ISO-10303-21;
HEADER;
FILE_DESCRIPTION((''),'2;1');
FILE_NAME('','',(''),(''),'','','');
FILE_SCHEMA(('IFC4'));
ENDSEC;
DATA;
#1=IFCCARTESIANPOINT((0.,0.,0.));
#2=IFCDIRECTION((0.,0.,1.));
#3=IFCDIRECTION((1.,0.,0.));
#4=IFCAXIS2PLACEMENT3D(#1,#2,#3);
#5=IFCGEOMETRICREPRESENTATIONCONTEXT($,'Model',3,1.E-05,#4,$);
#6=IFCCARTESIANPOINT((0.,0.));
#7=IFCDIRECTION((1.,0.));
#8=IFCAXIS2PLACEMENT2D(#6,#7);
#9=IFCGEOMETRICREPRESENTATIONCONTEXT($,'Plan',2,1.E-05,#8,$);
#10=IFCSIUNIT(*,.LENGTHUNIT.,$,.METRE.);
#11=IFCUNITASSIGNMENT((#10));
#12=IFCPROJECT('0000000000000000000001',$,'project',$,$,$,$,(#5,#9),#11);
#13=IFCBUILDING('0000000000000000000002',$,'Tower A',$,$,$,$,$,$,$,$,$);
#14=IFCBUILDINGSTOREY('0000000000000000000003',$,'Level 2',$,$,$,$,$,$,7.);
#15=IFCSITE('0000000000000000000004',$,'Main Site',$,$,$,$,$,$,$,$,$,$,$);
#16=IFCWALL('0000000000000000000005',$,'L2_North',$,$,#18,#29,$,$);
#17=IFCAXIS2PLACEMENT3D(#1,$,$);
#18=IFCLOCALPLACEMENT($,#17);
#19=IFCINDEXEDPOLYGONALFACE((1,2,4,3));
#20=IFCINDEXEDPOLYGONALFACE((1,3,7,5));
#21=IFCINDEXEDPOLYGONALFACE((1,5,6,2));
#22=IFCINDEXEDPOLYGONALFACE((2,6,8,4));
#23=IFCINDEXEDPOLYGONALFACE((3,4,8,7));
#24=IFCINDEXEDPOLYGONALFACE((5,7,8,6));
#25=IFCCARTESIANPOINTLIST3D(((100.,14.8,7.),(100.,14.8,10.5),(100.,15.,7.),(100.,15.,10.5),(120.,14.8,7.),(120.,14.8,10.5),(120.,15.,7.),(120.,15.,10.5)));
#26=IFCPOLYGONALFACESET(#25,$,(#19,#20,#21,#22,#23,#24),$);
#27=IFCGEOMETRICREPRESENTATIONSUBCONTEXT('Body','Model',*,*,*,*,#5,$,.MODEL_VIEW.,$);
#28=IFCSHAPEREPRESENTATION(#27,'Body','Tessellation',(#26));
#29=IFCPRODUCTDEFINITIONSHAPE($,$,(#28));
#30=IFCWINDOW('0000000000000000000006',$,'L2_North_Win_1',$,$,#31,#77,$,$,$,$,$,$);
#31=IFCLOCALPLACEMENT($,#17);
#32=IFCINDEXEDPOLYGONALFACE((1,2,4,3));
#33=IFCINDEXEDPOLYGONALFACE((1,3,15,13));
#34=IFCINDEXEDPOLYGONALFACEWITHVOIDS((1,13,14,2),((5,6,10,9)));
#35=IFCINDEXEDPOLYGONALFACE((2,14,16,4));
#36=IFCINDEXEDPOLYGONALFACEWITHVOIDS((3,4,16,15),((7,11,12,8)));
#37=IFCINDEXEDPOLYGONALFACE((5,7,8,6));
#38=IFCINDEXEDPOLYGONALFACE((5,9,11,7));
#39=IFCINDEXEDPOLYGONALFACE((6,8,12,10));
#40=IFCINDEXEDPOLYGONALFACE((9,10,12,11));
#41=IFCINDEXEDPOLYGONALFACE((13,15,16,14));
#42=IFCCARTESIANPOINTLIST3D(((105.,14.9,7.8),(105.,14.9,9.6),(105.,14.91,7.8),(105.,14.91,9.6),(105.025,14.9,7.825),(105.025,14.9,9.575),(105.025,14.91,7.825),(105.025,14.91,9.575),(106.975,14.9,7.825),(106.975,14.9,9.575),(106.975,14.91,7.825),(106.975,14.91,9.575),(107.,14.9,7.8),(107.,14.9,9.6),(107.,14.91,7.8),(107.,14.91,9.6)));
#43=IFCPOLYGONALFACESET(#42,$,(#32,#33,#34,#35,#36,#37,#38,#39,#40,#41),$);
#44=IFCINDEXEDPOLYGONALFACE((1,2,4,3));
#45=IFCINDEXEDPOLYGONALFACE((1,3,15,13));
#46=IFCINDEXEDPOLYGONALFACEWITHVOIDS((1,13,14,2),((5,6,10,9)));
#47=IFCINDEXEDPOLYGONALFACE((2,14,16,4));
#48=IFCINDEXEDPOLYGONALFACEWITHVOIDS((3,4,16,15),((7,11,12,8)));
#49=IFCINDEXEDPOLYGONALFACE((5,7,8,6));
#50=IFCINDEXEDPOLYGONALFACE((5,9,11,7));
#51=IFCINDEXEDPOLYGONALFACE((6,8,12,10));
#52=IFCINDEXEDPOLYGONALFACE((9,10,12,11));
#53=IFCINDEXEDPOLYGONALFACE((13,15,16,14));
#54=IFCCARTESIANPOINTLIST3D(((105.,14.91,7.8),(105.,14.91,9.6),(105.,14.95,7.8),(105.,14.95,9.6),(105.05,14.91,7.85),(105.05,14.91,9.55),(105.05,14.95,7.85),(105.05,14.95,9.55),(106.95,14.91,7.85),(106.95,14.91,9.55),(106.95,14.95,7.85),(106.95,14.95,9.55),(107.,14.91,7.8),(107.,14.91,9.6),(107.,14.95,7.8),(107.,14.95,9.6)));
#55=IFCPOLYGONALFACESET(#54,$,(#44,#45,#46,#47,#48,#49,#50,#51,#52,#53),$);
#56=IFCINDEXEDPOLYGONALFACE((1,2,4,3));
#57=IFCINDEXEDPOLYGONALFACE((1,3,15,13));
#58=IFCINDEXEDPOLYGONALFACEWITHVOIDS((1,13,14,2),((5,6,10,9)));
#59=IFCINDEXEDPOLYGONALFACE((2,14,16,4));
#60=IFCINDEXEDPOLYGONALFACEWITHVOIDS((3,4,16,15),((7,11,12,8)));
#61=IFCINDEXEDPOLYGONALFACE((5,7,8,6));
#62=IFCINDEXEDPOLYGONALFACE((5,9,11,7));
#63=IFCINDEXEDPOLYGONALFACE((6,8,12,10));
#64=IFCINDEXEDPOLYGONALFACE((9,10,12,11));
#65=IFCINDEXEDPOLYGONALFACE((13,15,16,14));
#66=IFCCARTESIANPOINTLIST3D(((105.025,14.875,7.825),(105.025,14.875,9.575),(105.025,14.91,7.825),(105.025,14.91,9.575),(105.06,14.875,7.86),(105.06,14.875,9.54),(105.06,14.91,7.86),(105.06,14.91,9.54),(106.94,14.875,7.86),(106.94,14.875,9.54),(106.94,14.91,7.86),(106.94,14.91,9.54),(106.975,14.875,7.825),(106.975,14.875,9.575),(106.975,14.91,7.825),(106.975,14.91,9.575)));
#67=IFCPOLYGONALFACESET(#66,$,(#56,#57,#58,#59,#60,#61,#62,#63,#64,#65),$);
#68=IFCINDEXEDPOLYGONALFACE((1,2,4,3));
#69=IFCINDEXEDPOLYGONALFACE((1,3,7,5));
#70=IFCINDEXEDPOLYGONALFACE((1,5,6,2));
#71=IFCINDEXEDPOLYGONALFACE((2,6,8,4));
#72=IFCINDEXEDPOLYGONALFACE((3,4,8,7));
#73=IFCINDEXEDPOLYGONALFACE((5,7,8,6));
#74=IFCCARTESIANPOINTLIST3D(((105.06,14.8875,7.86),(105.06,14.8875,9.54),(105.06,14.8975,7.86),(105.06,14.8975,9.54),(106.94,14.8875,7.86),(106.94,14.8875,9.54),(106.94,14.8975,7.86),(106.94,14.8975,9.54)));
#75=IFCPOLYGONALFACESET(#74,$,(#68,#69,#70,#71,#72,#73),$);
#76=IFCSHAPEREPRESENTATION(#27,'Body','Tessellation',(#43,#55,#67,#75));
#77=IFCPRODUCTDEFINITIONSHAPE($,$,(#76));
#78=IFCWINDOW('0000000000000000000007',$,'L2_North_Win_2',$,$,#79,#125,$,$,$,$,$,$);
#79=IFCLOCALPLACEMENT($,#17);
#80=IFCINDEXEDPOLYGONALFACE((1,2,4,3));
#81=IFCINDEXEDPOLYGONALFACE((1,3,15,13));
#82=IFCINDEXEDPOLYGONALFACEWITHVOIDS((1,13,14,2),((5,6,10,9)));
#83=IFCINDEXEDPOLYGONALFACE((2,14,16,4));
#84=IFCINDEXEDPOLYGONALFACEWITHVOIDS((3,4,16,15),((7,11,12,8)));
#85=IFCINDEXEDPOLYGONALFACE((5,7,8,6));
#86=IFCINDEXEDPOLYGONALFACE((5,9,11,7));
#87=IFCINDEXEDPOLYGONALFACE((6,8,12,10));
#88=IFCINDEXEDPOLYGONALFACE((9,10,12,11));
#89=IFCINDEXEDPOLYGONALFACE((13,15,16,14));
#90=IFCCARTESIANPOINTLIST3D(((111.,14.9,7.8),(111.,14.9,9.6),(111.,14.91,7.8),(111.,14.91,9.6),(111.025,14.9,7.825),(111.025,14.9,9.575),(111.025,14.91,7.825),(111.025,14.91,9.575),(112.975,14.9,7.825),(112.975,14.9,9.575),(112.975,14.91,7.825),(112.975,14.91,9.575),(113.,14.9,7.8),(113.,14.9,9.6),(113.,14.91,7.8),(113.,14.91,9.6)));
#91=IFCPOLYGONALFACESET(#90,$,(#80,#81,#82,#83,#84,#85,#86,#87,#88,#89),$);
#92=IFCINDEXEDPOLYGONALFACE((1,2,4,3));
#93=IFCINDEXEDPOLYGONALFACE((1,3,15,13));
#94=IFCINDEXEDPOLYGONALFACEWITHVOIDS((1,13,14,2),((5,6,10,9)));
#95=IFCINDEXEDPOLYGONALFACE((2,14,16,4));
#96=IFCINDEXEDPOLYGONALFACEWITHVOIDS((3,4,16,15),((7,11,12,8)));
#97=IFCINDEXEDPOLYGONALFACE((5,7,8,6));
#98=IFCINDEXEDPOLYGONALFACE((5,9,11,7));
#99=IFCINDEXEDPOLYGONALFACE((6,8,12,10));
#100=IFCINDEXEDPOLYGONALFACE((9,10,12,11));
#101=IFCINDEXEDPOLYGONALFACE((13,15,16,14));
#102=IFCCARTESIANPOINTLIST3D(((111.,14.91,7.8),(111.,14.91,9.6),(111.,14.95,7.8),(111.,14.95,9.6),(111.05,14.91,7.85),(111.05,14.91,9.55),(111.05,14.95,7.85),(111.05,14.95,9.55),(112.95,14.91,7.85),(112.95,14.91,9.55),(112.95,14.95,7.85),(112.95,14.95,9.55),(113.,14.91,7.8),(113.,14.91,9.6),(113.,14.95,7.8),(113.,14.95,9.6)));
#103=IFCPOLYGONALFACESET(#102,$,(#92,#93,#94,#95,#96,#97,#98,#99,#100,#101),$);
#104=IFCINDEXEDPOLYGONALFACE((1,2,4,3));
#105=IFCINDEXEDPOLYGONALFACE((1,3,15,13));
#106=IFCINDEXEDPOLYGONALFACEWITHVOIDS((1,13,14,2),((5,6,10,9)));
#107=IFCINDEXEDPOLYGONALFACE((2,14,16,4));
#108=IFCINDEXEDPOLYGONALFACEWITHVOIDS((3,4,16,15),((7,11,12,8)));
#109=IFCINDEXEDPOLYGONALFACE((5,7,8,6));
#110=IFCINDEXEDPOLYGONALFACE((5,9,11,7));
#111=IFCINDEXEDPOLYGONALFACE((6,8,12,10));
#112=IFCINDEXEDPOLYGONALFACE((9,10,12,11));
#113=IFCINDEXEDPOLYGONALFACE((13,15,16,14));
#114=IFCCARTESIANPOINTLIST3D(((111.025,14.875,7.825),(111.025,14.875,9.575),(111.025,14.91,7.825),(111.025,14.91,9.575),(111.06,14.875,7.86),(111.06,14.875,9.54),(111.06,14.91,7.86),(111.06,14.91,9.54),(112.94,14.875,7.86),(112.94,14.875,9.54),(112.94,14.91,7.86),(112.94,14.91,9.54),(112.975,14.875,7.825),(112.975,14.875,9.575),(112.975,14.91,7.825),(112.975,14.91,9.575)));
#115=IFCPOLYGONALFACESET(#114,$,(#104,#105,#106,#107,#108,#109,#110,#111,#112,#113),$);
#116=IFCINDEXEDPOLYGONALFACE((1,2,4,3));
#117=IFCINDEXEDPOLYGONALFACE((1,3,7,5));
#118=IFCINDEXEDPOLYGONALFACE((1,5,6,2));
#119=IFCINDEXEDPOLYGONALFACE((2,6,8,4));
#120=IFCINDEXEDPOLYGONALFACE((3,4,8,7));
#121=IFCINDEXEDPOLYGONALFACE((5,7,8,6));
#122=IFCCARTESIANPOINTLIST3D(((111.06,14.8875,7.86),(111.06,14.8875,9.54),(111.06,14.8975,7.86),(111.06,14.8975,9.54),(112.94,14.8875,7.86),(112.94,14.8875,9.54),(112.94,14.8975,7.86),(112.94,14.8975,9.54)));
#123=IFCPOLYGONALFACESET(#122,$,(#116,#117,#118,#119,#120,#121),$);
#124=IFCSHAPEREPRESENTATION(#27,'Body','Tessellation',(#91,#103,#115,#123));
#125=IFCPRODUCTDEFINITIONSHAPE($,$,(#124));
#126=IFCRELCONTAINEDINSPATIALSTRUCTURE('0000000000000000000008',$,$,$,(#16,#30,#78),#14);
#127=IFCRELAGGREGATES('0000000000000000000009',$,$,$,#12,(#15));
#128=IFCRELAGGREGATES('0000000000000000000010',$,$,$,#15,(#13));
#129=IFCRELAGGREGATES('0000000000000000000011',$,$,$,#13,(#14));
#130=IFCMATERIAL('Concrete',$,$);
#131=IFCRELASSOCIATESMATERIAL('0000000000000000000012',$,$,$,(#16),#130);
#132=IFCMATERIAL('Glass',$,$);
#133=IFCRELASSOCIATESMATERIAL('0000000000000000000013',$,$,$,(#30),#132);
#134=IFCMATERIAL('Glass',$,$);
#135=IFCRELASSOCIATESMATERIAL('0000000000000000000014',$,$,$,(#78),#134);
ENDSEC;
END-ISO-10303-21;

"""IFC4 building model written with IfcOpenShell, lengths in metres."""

from ifc_helpers import new_model, si_unit, frame, origin_with_axes, origin_2d_with_axis, place, context, subcontext, project, spatial, line, indexed_curve, outline, extrude, material, element, fill, save


model = new_model("IFC4")

# Units and contexts
model_context = context("Model", 3, precision=1e-05, world=origin_with_axes())
plan_context = context("Plan", 2, precision=1e-05, world=origin_2d_with_axis())
body_context = subcontext(model_context, "Body", "Model", "MODEL_VIEW")
ifc_project = project(units=[si_unit("LENGTHUNIT", "METRE")], contexts=[model_context, plan_context])

# Site, building, storey
site = spatial("IfcSite", under=ifc_project, Name="Main Site")
building = spatial("IfcBuilding", under=site, Name="Tower A")
storey = spatial("IfcBuildingStorey", under=building, Name="Level 2", Elevation=7.0)

# Wall, openings, windows
ifc_material_1 = material(Name="Concrete")
wall_1_placement = place(None, frame((120.0, 15.0, 7.0), z_axis=(0.0, 0.0, 1.0), x_axis=(-1.0, 0.0, 0.0)))
wall_1 = element("IfcWall", 1, at=wall_1_placement, inside=storey, material=ifc_material_1, Name="L2_North", context=body_context, shape_type="SweptSolid", body=[
    extrude(outline(indexed_curve([(0.0, 0.0), (0.0, 0.2), (20.0, 0.2), (20.0, 0.0), (0.0, 0.0)], self_intersect=False)), origin_with_axes(), (0.0, 0.0, 1.0), 3.5),
])
opening_1_placement = place(wall_1_placement, frame((13.0, 0.0, 0.8), z_axis=(0.0, 0.0, 1.0), x_axis=(-1.0, 0.0, 0.0)))
opening_1 = element("IfcOpeningElement", 2, at=opening_1_placement, cuts=wall_1, context=body_context, shape_type="SweptSolid", body=[
    extrude(outline(indexed_curve([(0.0, 0.0), (0.0, 0.25), (2.0, 0.25), (2.0, 0.0), (0.0, 0.0)], self_intersect=False)), origin_with_axes(), (0.0, 0.0, 1.0), 1.8),
])
opening_2_placement = place(wall_1_placement, frame((7.0, 0.0, 0.8), z_axis=(0.0, 0.0, 1.0), x_axis=(-1.0, 0.0, 0.0)))
opening_2 = element("IfcOpeningElement", 3, at=opening_2_placement, cuts=wall_1, context=body_context, shape_type="SweptSolid", body=[
    extrude(outline(indexed_curve([(0.0, 0.0), (0.0, 0.25), (2.0, 0.25), (2.0, 0.0), (0.0, 0.0)], self_intersect=False)), origin_with_axes(), (0.0, 0.0, 1.0), 1.8),
])
ifc_material_2 = material(Name="Glass")
window_1_placement = place(None, frame((107.0, 15.0, 7.8), z_axis=(0.0, 0.0, 1.0), x_axis=(-1.0, 0.0, 0.0)))
window_1 = element("IfcWindow", 4, at=window_1_placement, inside=storey, material=ifc_material_2, Name="L2_North_Win_1", context=body_context, shape_type="SweptSolid", body=[
    extrude(outline(indexed_curve([(0.0, 0.0), (2.0, 0.0), (2.0, 1.8), (0.0, 1.8)], segments=[line(1, 2, 3, 4, 1)]), holes=[indexed_curve([(0.025, 0.025), (1.975, 0.025), (1.975, 1.775), (0.025, 1.775)], segments=[line(1, 2, 3, 4, 1)])]), frame((0.0, 0.09, 0.0), z_axis=(0.0, -1.0, 0.0), x_axis=(1.0, 0.0, 0.0)), (0.0, 0.0, -1.0), 0.01),
    extrude(outline(indexed_curve([(0.0, 0.0), (2.0, 0.0), (2.0, 1.8), (0.0, 1.8)], segments=[line(1, 2, 3, 4, 1)]), holes=[indexed_curve([(0.05, 0.05), (1.95, 0.05), (1.95, 1.75), (0.05, 1.75)], segments=[line(1, 2, 3, 4, 1)])]), frame((0.0, 0.05, 0.0), z_axis=(0.0, -1.0, 0.0), x_axis=(1.0, 0.0, 0.0)), (0.0, 0.0, -1.0), 0.04),
    extrude(outline(indexed_curve([(0.0, 0.0), (1.95, 0.0), (1.95, 1.75), (0.0, 1.75)], segments=[line(1, 2, 3, 4, 1)]), holes=[indexed_curve([(0.035, 0.035), (1.915, 0.035), (1.915, 1.715), (0.035, 1.715)], segments=[line(1, 2, 3, 4, 1)])]), frame((0.025, 0.09, 0.025), z_axis=(0.0, -1.0, 0.0), x_axis=(1.0, 0.0, 0.0)), (0.0, 0.0, -1.0), 0.035),
    extrude(outline(indexed_curve([(0.035, 0.035), (1.915, 0.035), (1.915, 1.715), (0.035, 1.715)], segments=[line(1, 2, 3, 4, 1)])), frame((0.025, 0.1025, 0.025), z_axis=(0.0, -1.0, 0.0), x_axis=(1.0, 0.0, 0.0)), (0.0, 0.0, -1.0), 0.01),
])
fill(opening_1, window_1)
ifc_material_3 = material(Name="Glass")
window_2_placement = place(None, frame((113.0, 15.0, 7.8), z_axis=(0.0, 0.0, 1.0), x_axis=(-1.0, 0.0, 0.0)))
window_2 = element("IfcWindow", 5, at=window_2_placement, inside=storey, material=ifc_material_3, Name="L2_North_Win_2", context=body_context, shape_type="SweptSolid", body=[
    extrude(outline(indexed_curve([(0.0, 0.0), (2.0, 0.0), (2.0, 1.8), (0.0, 1.8)], segments=[line(1, 2, 3, 4, 1)]), holes=[indexed_curve([(0.025, 0.025), (1.975, 0.025), (1.975, 1.775), (0.025, 1.775)], segments=[line(1, 2, 3, 4, 1)])]), frame((0.0, 0.09, 0.0), z_axis=(0.0, -1.0, 0.0), x_axis=(1.0, 0.0, 0.0)), (0.0, 0.0, -1.0), 0.01),
    extrude(outline(indexed_curve([(0.0, 0.0), (2.0, 0.0), (2.0, 1.8), (0.0, 1.8)], segments=[line(1, 2, 3, 4, 1)]), holes=[indexed_curve([(0.05, 0.05), (1.95, 0.05), (1.95, 1.75), (0.05, 1.75)], segments=[line(1, 2, 3, 4, 1)])]), frame((0.0, 0.05, 0.0), z_axis=(0.0, -1.0, 0.0), x_axis=(1.0, 0.0, 0.0)), (0.0, 0.0, -1.0), 0.04),
    extrude(outline(indexed_curve([(0.0, 0.0), (1.95, 0.0), (1.95, 1.75), (0.0, 1.75)], segments=[line(1, 2, 3, 4, 1)]), holes=[indexed_curve([(0.035, 0.035), (1.915, 0.035), (1.915, 1.715), (0.035, 1.715)], segments=[line(1, 2, 3, 4, 1)])]), frame((0.025, 0.09, 0.025), z_axis=(0.0, -1.0, 0.0), x_axis=(1.0, 0.0, 0.0)), (0.0, 0.0, -1.0), 0.035),
    extrude(outline(indexed_curve([(0.035, 0.035), (1.915, 0.035), (1.915, 1.715), (0.035, 1.715)], segments=[line(1, 2, 3, 4, 1)])), frame((0.025, 0.1025, 0.025), z_axis=(0.0, -1.0, 0.0), x_axis=(1.0, 0.0, 0.0)), (0.0, 0.0, -1.0), 0.01),
])
fill(opening_2, window_2)

save(model, "model.ifc")
